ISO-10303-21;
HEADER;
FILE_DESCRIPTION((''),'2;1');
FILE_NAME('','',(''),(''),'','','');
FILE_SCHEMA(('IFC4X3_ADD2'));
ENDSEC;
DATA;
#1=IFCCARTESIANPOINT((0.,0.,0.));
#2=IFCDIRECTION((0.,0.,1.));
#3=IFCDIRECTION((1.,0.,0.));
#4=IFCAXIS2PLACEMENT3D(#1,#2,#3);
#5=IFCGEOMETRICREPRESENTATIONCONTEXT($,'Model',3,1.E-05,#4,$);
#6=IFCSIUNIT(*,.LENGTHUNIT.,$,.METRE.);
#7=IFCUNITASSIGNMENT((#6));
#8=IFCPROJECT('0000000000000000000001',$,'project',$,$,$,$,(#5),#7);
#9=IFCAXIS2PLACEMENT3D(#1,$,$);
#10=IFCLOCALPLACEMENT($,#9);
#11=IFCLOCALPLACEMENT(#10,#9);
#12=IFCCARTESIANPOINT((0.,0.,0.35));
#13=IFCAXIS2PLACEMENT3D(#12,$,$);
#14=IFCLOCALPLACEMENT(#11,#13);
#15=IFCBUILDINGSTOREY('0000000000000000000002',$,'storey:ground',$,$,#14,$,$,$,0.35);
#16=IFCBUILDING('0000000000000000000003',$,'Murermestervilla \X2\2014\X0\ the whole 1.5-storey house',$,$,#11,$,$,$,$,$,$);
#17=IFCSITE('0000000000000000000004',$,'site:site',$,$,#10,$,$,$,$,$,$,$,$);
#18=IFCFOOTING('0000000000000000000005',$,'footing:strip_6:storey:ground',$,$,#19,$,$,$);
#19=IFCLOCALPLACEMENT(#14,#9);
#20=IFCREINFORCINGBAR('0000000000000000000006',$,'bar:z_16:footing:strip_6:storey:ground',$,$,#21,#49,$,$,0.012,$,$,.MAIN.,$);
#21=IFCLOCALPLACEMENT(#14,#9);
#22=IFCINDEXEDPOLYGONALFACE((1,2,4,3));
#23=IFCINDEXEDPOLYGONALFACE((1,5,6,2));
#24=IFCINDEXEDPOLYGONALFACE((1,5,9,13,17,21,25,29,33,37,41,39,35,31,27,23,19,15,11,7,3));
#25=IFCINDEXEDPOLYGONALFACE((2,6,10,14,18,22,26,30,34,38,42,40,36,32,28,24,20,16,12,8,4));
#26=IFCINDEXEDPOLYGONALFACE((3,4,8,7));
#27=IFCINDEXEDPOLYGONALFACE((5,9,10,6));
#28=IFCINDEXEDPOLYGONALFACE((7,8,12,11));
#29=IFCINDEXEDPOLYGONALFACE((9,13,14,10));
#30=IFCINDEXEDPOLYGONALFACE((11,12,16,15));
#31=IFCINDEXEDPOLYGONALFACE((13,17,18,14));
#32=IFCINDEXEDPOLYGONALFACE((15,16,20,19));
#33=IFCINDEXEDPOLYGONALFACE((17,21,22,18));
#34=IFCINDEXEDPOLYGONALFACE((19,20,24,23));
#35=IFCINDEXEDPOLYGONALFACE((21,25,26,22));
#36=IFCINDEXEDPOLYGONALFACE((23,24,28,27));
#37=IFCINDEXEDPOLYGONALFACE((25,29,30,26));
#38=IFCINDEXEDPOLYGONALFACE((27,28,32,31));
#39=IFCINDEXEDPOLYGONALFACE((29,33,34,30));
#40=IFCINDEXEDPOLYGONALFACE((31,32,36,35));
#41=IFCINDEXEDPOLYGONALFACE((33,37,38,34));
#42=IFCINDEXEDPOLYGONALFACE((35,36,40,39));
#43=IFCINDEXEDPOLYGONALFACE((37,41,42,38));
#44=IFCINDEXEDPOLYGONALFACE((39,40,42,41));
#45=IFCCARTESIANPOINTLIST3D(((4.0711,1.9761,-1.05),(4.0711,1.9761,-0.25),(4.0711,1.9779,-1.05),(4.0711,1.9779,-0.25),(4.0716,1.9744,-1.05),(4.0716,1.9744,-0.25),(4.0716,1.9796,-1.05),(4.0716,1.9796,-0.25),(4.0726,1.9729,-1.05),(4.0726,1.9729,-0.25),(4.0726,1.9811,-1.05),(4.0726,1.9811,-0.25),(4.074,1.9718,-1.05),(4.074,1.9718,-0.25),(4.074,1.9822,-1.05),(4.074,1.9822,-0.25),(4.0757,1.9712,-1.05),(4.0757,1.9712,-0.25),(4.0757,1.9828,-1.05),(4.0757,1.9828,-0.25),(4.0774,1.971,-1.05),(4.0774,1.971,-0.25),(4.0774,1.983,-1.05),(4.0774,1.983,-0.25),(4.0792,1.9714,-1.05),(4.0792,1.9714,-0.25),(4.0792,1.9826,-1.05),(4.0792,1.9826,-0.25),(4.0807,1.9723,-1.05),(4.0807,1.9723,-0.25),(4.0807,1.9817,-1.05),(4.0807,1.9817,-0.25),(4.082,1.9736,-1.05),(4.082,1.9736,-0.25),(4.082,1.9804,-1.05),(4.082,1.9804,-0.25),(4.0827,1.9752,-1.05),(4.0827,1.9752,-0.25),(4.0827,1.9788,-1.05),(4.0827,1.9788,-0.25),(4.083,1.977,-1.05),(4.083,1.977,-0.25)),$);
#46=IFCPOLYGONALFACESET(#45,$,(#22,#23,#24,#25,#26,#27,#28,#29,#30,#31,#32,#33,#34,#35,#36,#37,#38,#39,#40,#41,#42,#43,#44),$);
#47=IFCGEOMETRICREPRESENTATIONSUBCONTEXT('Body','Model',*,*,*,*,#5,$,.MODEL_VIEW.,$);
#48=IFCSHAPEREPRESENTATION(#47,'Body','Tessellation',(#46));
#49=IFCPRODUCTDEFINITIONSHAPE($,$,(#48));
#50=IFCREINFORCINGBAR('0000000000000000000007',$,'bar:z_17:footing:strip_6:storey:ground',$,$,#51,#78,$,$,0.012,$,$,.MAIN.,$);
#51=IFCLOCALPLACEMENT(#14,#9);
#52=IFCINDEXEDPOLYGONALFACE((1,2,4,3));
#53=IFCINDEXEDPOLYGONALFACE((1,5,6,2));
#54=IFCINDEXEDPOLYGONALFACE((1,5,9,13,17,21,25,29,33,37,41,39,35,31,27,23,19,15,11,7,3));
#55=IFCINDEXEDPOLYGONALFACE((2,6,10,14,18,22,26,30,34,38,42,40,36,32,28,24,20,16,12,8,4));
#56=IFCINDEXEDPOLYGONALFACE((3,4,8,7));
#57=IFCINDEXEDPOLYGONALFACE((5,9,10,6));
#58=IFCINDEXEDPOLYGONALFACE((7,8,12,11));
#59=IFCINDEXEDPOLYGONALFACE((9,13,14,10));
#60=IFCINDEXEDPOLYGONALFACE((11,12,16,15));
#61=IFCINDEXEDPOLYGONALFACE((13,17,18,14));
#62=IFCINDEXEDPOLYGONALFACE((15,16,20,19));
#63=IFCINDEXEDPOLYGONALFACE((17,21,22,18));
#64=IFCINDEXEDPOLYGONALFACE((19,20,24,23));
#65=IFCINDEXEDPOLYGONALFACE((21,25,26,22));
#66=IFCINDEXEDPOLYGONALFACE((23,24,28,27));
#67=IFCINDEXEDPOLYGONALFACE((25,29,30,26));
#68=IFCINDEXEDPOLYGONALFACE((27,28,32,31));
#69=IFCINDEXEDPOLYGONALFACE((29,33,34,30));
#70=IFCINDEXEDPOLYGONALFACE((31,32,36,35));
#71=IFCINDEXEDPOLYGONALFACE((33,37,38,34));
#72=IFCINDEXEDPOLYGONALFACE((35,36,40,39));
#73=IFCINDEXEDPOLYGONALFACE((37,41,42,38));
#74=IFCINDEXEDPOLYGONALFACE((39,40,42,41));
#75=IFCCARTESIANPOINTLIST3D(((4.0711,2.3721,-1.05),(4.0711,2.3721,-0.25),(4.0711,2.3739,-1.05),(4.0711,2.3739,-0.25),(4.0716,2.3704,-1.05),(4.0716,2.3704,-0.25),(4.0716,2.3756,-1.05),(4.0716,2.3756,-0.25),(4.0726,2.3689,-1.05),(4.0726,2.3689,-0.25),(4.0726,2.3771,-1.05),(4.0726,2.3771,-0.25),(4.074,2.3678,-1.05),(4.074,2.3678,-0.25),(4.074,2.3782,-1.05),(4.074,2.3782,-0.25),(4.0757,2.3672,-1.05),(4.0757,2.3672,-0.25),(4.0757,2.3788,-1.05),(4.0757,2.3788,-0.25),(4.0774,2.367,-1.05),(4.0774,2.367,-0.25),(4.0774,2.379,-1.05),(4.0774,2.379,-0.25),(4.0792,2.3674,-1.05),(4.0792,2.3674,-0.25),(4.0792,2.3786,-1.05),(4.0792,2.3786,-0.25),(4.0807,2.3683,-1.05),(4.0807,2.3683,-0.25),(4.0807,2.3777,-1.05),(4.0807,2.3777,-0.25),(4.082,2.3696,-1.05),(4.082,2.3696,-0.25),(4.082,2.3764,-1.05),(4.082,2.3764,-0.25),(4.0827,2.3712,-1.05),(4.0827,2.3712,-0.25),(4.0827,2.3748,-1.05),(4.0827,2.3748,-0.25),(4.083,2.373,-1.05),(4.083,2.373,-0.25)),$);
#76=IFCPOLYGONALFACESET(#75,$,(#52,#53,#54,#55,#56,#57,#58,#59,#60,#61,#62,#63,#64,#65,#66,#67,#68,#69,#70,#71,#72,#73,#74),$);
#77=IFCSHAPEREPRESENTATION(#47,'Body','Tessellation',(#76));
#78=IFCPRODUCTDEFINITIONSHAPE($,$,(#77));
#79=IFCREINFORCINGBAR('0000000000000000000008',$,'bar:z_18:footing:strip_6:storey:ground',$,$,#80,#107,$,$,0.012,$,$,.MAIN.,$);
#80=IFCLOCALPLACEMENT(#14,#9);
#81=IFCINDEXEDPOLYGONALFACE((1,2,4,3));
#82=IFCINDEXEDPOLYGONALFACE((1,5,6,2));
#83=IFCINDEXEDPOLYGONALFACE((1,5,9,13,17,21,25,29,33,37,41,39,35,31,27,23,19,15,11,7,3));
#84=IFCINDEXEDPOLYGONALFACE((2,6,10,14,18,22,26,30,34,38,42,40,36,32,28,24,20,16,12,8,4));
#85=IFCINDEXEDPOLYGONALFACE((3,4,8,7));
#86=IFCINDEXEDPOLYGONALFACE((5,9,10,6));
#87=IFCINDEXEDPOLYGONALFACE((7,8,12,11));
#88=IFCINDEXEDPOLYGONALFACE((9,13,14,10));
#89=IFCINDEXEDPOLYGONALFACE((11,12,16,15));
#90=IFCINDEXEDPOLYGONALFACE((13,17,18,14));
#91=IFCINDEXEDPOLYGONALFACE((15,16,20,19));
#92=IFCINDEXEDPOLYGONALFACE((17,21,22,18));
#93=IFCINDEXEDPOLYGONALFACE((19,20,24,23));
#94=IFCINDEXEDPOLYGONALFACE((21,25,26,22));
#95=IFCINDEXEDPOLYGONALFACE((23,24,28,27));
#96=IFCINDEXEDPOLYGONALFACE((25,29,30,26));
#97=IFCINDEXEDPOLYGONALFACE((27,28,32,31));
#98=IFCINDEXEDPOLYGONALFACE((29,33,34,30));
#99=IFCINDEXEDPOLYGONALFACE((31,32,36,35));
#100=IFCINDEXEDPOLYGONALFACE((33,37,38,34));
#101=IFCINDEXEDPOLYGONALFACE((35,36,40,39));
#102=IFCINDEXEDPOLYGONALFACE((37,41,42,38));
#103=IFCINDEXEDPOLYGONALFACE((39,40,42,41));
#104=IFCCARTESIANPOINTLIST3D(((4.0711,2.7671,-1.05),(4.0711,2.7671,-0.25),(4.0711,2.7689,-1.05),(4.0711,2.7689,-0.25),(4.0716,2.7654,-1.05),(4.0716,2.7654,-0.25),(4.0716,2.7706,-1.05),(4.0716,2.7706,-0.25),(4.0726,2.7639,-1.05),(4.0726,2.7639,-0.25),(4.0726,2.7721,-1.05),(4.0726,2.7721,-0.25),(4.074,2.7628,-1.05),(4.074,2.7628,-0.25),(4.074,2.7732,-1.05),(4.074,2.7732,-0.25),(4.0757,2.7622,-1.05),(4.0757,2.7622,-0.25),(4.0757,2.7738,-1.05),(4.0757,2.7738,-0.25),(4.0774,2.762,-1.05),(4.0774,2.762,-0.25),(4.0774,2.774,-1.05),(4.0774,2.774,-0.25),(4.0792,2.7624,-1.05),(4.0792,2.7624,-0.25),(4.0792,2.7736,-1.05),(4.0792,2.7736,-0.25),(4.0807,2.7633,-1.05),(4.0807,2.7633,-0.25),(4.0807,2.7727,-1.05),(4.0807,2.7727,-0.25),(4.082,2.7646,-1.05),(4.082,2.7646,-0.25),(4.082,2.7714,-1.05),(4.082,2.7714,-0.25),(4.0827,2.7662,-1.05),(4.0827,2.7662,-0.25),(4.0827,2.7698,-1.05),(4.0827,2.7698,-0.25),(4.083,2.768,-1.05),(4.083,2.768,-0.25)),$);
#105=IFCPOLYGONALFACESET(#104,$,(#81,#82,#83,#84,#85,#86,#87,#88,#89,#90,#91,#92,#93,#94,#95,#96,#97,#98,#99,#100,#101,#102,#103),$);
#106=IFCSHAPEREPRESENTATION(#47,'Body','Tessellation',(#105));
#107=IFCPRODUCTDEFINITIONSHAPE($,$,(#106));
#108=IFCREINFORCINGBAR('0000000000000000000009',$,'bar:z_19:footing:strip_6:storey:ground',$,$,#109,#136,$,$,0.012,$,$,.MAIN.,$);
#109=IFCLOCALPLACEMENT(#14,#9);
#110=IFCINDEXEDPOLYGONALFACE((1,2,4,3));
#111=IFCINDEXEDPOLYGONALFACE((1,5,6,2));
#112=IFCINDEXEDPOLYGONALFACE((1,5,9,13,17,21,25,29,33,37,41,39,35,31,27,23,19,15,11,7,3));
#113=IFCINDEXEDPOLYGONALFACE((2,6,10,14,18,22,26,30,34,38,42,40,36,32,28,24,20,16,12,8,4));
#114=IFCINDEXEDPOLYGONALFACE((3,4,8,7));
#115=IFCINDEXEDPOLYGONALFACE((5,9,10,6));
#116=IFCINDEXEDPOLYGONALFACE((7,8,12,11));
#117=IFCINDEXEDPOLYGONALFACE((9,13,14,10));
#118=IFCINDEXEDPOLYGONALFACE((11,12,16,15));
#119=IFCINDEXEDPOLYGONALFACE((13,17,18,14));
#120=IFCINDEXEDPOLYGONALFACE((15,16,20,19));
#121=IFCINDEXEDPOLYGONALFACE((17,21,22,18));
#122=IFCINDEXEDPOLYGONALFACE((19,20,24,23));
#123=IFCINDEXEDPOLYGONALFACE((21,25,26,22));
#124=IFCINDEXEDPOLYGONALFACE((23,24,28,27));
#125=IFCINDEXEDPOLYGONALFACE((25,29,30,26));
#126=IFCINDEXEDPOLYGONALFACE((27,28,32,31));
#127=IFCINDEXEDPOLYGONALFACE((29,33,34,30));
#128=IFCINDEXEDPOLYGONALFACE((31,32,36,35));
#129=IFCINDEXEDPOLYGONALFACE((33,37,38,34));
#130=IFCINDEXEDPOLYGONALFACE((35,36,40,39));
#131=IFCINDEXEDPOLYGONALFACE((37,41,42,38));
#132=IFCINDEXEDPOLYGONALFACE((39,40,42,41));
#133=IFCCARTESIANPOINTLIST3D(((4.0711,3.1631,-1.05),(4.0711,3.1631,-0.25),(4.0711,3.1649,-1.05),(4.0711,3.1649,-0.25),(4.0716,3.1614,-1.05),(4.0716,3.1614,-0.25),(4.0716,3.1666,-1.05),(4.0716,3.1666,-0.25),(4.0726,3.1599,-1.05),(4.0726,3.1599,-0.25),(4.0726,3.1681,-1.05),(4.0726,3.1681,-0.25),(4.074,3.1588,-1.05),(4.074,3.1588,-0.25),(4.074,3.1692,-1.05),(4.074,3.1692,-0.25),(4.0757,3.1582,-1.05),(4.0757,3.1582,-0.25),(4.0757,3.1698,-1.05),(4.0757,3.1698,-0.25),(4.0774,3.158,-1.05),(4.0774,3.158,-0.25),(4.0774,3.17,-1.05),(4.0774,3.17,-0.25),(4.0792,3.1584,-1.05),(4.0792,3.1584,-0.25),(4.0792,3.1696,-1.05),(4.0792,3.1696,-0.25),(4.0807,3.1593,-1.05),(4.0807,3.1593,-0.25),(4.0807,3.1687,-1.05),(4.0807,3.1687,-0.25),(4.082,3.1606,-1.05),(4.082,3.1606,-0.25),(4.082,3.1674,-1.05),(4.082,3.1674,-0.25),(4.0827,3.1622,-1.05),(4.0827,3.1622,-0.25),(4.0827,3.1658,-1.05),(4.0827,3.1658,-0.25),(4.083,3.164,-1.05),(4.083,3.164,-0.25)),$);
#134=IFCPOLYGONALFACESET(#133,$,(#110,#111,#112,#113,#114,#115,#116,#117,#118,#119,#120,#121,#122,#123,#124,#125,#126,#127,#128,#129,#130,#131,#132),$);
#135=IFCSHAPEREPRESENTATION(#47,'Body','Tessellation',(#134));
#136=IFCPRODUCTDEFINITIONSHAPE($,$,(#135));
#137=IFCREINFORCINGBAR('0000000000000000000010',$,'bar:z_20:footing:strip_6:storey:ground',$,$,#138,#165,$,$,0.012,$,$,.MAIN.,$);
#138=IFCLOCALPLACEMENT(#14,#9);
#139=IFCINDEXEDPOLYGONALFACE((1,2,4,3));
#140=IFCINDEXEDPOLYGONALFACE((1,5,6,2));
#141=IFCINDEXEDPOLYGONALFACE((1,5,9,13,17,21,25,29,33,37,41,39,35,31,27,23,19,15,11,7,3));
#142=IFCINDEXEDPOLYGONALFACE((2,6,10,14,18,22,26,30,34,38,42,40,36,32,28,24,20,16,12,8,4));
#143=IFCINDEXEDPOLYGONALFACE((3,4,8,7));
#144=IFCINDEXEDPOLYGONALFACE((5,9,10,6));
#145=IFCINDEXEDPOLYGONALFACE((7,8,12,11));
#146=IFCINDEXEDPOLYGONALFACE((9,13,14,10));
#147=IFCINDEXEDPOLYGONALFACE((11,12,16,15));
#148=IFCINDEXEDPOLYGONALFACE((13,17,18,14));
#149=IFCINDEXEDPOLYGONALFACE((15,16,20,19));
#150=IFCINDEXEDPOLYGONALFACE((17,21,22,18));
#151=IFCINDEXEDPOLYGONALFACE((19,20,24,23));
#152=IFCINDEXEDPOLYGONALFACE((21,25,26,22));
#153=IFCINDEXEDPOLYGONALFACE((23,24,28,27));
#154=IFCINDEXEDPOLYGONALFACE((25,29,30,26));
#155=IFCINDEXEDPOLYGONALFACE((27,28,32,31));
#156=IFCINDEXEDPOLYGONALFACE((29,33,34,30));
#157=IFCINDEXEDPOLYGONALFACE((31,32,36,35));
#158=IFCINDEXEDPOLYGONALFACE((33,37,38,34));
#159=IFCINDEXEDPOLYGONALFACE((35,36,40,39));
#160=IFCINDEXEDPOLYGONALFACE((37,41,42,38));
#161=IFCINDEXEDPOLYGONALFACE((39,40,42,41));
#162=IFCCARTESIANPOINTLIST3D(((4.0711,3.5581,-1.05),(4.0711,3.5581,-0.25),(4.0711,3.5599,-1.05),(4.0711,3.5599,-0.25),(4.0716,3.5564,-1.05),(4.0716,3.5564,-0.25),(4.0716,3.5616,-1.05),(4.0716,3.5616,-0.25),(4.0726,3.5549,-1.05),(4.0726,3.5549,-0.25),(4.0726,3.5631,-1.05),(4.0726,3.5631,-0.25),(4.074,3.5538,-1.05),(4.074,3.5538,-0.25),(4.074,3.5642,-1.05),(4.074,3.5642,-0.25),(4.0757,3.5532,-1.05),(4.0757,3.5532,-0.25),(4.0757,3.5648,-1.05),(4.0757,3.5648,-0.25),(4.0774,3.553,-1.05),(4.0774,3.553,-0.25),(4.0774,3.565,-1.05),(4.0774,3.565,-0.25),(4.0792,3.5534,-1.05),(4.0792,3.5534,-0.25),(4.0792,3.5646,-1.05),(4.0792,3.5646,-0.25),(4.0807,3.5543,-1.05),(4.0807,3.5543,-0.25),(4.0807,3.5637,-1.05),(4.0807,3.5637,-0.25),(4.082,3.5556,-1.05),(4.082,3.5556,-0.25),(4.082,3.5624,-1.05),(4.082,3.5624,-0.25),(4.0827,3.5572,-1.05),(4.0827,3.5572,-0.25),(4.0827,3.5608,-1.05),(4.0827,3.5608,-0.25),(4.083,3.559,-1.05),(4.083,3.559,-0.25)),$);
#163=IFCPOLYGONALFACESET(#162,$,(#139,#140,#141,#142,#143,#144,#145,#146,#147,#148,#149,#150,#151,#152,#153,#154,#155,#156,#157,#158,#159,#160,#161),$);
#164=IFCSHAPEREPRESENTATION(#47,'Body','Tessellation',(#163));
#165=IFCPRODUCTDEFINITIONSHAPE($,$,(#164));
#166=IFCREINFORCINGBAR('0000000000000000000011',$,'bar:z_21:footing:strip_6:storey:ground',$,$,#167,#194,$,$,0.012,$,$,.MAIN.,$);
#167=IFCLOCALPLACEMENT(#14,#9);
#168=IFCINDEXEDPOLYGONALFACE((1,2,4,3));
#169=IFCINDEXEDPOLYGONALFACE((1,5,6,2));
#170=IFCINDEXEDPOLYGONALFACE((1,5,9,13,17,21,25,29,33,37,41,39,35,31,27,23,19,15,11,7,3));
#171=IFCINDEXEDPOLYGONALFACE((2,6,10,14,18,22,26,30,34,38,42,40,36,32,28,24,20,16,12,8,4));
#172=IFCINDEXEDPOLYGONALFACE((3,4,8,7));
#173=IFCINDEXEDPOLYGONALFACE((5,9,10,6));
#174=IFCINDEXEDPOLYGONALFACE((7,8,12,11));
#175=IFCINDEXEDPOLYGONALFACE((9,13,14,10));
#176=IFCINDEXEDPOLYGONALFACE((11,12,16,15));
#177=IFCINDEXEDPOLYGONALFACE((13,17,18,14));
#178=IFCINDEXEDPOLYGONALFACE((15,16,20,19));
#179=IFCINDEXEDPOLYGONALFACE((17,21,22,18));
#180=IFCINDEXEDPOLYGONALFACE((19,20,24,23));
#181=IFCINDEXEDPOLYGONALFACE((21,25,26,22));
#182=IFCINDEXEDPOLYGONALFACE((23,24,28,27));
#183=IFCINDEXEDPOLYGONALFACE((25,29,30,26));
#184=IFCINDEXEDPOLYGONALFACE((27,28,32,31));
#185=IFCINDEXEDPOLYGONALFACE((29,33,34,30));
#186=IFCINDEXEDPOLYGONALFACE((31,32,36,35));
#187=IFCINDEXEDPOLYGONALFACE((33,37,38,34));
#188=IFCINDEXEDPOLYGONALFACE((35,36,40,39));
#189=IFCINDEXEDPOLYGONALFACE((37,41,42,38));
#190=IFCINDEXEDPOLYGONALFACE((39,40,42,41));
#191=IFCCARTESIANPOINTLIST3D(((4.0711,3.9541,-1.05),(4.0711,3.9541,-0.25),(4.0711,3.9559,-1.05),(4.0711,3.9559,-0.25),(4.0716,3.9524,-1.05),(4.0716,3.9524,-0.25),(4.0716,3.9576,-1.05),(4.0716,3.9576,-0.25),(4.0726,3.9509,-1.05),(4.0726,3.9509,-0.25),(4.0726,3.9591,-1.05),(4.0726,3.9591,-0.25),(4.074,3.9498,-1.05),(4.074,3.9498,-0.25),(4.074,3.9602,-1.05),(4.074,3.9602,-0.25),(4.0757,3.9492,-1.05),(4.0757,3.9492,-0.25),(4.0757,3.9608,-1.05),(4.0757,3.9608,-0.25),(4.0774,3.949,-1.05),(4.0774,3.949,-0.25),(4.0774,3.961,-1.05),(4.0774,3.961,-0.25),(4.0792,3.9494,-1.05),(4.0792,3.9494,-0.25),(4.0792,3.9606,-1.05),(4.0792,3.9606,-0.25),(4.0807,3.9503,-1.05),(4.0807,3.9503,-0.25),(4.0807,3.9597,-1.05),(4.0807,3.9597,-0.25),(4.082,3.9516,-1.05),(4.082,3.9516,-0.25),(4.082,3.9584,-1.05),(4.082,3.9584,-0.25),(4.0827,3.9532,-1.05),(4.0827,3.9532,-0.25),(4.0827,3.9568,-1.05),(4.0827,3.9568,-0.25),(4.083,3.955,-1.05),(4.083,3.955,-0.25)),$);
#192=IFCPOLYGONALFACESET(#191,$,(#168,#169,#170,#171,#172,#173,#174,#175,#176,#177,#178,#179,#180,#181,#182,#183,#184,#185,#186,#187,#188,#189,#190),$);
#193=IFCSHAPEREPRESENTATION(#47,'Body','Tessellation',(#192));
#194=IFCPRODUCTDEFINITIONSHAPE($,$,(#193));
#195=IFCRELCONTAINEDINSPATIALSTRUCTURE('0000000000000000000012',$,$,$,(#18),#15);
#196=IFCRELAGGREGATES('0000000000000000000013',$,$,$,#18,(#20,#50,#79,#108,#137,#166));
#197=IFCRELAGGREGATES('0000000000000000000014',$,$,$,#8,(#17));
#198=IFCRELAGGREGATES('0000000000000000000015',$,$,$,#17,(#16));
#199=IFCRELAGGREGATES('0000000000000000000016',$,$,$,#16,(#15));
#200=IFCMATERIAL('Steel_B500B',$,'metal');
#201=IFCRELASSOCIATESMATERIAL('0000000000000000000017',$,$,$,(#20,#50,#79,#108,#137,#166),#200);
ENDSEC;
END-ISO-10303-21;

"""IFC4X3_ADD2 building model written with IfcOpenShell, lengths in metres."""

from ifc_helpers import new_model, entity, si_unit, frame, origin, origin_with_axes, place, context, subcontext, project, spatial, material, element, aggregate, save


model = new_model("IFC4X3_ADD2")

# Units and contexts
model_context = context("Model", 3, precision=1e-05, world=origin_with_axes())
body_context = subcontext(model_context, "Body", "Model", "MODEL_VIEW")
ifc_project = project(units=[si_unit("LENGTHUNIT", "METRE")], contexts=[model_context])

# Site, building, storey
placement_1 = place(None, origin())
site = spatial("IfcSite", under=ifc_project, at=placement_1, Name="site:site")
building_placement = place(placement_1, origin())
building = spatial("IfcBuilding", under=site, at=building_placement, Name="Murermestervilla — the whole 1.5-storey house")
storey_placement = place(building_placement, frame((0.0, 0.0, 0.35)))
storey = spatial("IfcBuildingStorey", under=building, at=storey_placement, Name="storey:ground", Elevation=0.35)

# Footing, reinforcing bars
placement_2 = place(storey_placement, frame((0.0, 0.0, -0.35)))
footing_1 = element("IfcFooting", 1, at=placement_2, inside=storey, Name="footing:strip_6:storey:ground")
ifc_material = material(Name="Steel_B500B", Category="metal")
reinforcing_bar_1 = element("IfcReinforcingBar", 2, at=placement_1, material=ifc_material, Name="bar:z_16:footing:strip_6:storey:ground", NominalDiameter=0.012, PredefinedType="MAIN", context=body_context, shape_type="AdvancedSweptSolid", body=[
    entity("IfcSweptDiskSolid", entity("IfcPolyline", [entity("IfcCartesianPoint", [4.077, 1.977, -0.7]), entity("IfcCartesianPoint", [4.077, 1.977, 0.1])]), 0.006),
])
reinforcing_bar_2 = element("IfcReinforcingBar", 3, at=placement_1, material=ifc_material, Name="bar:z_17:footing:strip_6:storey:ground", NominalDiameter=0.012, PredefinedType="MAIN", context=body_context, shape_type="AdvancedSweptSolid", body=[
    entity("IfcSweptDiskSolid", entity("IfcPolyline", [entity("IfcCartesianPoint", [4.077, 2.373, -0.7]), entity("IfcCartesianPoint", [4.077, 2.373, 0.1])]), 0.006),
])
reinforcing_bar_3 = element("IfcReinforcingBar", 4, at=placement_1, material=ifc_material, Name="bar:z_18:footing:strip_6:storey:ground", NominalDiameter=0.012, PredefinedType="MAIN", context=body_context, shape_type="AdvancedSweptSolid", body=[
    entity("IfcSweptDiskSolid", entity("IfcPolyline", [entity("IfcCartesianPoint", [4.077, 2.768, -0.7]), entity("IfcCartesianPoint", [4.077, 2.768, 0.1])]), 0.006),
])
reinforcing_bar_4 = element("IfcReinforcingBar", 5, at=placement_1, material=ifc_material, Name="bar:z_19:footing:strip_6:storey:ground", NominalDiameter=0.012, PredefinedType="MAIN", context=body_context, shape_type="AdvancedSweptSolid", body=[
    entity("IfcSweptDiskSolid", entity("IfcPolyline", [entity("IfcCartesianPoint", [4.077, 3.164, -0.7]), entity("IfcCartesianPoint", [4.077, 3.164, 0.1])]), 0.006),
])
reinforcing_bar_5 = element("IfcReinforcingBar", 6, at=placement_1, material=ifc_material, Name="bar:z_20:footing:strip_6:storey:ground", NominalDiameter=0.012, PredefinedType="MAIN", context=body_context, shape_type="AdvancedSweptSolid", body=[
    entity("IfcSweptDiskSolid", entity("IfcPolyline", [entity("IfcCartesianPoint", [4.077, 3.559, -0.7]), entity("IfcCartesianPoint", [4.077, 3.559, 0.1])]), 0.006),
])
reinforcing_bar_6 = element("IfcReinforcingBar", 7, at=placement_1, material=ifc_material, Name="bar:z_21:footing:strip_6:storey:ground", NominalDiameter=0.012, PredefinedType="MAIN", context=body_context, shape_type="AdvancedSweptSolid", body=[
    entity("IfcSweptDiskSolid", entity("IfcPolyline", [entity("IfcCartesianPoint", [4.077, 3.955, -0.7]), entity("IfcCartesianPoint", [4.077, 3.955, 0.1])]), 0.006),
])
aggregate(footing_1, [reinforcing_bar_1, reinforcing_bar_2, reinforcing_bar_3, reinforcing_bar_4, reinforcing_bar_5, reinforcing_bar_6])

save(model, "model.ifc")
